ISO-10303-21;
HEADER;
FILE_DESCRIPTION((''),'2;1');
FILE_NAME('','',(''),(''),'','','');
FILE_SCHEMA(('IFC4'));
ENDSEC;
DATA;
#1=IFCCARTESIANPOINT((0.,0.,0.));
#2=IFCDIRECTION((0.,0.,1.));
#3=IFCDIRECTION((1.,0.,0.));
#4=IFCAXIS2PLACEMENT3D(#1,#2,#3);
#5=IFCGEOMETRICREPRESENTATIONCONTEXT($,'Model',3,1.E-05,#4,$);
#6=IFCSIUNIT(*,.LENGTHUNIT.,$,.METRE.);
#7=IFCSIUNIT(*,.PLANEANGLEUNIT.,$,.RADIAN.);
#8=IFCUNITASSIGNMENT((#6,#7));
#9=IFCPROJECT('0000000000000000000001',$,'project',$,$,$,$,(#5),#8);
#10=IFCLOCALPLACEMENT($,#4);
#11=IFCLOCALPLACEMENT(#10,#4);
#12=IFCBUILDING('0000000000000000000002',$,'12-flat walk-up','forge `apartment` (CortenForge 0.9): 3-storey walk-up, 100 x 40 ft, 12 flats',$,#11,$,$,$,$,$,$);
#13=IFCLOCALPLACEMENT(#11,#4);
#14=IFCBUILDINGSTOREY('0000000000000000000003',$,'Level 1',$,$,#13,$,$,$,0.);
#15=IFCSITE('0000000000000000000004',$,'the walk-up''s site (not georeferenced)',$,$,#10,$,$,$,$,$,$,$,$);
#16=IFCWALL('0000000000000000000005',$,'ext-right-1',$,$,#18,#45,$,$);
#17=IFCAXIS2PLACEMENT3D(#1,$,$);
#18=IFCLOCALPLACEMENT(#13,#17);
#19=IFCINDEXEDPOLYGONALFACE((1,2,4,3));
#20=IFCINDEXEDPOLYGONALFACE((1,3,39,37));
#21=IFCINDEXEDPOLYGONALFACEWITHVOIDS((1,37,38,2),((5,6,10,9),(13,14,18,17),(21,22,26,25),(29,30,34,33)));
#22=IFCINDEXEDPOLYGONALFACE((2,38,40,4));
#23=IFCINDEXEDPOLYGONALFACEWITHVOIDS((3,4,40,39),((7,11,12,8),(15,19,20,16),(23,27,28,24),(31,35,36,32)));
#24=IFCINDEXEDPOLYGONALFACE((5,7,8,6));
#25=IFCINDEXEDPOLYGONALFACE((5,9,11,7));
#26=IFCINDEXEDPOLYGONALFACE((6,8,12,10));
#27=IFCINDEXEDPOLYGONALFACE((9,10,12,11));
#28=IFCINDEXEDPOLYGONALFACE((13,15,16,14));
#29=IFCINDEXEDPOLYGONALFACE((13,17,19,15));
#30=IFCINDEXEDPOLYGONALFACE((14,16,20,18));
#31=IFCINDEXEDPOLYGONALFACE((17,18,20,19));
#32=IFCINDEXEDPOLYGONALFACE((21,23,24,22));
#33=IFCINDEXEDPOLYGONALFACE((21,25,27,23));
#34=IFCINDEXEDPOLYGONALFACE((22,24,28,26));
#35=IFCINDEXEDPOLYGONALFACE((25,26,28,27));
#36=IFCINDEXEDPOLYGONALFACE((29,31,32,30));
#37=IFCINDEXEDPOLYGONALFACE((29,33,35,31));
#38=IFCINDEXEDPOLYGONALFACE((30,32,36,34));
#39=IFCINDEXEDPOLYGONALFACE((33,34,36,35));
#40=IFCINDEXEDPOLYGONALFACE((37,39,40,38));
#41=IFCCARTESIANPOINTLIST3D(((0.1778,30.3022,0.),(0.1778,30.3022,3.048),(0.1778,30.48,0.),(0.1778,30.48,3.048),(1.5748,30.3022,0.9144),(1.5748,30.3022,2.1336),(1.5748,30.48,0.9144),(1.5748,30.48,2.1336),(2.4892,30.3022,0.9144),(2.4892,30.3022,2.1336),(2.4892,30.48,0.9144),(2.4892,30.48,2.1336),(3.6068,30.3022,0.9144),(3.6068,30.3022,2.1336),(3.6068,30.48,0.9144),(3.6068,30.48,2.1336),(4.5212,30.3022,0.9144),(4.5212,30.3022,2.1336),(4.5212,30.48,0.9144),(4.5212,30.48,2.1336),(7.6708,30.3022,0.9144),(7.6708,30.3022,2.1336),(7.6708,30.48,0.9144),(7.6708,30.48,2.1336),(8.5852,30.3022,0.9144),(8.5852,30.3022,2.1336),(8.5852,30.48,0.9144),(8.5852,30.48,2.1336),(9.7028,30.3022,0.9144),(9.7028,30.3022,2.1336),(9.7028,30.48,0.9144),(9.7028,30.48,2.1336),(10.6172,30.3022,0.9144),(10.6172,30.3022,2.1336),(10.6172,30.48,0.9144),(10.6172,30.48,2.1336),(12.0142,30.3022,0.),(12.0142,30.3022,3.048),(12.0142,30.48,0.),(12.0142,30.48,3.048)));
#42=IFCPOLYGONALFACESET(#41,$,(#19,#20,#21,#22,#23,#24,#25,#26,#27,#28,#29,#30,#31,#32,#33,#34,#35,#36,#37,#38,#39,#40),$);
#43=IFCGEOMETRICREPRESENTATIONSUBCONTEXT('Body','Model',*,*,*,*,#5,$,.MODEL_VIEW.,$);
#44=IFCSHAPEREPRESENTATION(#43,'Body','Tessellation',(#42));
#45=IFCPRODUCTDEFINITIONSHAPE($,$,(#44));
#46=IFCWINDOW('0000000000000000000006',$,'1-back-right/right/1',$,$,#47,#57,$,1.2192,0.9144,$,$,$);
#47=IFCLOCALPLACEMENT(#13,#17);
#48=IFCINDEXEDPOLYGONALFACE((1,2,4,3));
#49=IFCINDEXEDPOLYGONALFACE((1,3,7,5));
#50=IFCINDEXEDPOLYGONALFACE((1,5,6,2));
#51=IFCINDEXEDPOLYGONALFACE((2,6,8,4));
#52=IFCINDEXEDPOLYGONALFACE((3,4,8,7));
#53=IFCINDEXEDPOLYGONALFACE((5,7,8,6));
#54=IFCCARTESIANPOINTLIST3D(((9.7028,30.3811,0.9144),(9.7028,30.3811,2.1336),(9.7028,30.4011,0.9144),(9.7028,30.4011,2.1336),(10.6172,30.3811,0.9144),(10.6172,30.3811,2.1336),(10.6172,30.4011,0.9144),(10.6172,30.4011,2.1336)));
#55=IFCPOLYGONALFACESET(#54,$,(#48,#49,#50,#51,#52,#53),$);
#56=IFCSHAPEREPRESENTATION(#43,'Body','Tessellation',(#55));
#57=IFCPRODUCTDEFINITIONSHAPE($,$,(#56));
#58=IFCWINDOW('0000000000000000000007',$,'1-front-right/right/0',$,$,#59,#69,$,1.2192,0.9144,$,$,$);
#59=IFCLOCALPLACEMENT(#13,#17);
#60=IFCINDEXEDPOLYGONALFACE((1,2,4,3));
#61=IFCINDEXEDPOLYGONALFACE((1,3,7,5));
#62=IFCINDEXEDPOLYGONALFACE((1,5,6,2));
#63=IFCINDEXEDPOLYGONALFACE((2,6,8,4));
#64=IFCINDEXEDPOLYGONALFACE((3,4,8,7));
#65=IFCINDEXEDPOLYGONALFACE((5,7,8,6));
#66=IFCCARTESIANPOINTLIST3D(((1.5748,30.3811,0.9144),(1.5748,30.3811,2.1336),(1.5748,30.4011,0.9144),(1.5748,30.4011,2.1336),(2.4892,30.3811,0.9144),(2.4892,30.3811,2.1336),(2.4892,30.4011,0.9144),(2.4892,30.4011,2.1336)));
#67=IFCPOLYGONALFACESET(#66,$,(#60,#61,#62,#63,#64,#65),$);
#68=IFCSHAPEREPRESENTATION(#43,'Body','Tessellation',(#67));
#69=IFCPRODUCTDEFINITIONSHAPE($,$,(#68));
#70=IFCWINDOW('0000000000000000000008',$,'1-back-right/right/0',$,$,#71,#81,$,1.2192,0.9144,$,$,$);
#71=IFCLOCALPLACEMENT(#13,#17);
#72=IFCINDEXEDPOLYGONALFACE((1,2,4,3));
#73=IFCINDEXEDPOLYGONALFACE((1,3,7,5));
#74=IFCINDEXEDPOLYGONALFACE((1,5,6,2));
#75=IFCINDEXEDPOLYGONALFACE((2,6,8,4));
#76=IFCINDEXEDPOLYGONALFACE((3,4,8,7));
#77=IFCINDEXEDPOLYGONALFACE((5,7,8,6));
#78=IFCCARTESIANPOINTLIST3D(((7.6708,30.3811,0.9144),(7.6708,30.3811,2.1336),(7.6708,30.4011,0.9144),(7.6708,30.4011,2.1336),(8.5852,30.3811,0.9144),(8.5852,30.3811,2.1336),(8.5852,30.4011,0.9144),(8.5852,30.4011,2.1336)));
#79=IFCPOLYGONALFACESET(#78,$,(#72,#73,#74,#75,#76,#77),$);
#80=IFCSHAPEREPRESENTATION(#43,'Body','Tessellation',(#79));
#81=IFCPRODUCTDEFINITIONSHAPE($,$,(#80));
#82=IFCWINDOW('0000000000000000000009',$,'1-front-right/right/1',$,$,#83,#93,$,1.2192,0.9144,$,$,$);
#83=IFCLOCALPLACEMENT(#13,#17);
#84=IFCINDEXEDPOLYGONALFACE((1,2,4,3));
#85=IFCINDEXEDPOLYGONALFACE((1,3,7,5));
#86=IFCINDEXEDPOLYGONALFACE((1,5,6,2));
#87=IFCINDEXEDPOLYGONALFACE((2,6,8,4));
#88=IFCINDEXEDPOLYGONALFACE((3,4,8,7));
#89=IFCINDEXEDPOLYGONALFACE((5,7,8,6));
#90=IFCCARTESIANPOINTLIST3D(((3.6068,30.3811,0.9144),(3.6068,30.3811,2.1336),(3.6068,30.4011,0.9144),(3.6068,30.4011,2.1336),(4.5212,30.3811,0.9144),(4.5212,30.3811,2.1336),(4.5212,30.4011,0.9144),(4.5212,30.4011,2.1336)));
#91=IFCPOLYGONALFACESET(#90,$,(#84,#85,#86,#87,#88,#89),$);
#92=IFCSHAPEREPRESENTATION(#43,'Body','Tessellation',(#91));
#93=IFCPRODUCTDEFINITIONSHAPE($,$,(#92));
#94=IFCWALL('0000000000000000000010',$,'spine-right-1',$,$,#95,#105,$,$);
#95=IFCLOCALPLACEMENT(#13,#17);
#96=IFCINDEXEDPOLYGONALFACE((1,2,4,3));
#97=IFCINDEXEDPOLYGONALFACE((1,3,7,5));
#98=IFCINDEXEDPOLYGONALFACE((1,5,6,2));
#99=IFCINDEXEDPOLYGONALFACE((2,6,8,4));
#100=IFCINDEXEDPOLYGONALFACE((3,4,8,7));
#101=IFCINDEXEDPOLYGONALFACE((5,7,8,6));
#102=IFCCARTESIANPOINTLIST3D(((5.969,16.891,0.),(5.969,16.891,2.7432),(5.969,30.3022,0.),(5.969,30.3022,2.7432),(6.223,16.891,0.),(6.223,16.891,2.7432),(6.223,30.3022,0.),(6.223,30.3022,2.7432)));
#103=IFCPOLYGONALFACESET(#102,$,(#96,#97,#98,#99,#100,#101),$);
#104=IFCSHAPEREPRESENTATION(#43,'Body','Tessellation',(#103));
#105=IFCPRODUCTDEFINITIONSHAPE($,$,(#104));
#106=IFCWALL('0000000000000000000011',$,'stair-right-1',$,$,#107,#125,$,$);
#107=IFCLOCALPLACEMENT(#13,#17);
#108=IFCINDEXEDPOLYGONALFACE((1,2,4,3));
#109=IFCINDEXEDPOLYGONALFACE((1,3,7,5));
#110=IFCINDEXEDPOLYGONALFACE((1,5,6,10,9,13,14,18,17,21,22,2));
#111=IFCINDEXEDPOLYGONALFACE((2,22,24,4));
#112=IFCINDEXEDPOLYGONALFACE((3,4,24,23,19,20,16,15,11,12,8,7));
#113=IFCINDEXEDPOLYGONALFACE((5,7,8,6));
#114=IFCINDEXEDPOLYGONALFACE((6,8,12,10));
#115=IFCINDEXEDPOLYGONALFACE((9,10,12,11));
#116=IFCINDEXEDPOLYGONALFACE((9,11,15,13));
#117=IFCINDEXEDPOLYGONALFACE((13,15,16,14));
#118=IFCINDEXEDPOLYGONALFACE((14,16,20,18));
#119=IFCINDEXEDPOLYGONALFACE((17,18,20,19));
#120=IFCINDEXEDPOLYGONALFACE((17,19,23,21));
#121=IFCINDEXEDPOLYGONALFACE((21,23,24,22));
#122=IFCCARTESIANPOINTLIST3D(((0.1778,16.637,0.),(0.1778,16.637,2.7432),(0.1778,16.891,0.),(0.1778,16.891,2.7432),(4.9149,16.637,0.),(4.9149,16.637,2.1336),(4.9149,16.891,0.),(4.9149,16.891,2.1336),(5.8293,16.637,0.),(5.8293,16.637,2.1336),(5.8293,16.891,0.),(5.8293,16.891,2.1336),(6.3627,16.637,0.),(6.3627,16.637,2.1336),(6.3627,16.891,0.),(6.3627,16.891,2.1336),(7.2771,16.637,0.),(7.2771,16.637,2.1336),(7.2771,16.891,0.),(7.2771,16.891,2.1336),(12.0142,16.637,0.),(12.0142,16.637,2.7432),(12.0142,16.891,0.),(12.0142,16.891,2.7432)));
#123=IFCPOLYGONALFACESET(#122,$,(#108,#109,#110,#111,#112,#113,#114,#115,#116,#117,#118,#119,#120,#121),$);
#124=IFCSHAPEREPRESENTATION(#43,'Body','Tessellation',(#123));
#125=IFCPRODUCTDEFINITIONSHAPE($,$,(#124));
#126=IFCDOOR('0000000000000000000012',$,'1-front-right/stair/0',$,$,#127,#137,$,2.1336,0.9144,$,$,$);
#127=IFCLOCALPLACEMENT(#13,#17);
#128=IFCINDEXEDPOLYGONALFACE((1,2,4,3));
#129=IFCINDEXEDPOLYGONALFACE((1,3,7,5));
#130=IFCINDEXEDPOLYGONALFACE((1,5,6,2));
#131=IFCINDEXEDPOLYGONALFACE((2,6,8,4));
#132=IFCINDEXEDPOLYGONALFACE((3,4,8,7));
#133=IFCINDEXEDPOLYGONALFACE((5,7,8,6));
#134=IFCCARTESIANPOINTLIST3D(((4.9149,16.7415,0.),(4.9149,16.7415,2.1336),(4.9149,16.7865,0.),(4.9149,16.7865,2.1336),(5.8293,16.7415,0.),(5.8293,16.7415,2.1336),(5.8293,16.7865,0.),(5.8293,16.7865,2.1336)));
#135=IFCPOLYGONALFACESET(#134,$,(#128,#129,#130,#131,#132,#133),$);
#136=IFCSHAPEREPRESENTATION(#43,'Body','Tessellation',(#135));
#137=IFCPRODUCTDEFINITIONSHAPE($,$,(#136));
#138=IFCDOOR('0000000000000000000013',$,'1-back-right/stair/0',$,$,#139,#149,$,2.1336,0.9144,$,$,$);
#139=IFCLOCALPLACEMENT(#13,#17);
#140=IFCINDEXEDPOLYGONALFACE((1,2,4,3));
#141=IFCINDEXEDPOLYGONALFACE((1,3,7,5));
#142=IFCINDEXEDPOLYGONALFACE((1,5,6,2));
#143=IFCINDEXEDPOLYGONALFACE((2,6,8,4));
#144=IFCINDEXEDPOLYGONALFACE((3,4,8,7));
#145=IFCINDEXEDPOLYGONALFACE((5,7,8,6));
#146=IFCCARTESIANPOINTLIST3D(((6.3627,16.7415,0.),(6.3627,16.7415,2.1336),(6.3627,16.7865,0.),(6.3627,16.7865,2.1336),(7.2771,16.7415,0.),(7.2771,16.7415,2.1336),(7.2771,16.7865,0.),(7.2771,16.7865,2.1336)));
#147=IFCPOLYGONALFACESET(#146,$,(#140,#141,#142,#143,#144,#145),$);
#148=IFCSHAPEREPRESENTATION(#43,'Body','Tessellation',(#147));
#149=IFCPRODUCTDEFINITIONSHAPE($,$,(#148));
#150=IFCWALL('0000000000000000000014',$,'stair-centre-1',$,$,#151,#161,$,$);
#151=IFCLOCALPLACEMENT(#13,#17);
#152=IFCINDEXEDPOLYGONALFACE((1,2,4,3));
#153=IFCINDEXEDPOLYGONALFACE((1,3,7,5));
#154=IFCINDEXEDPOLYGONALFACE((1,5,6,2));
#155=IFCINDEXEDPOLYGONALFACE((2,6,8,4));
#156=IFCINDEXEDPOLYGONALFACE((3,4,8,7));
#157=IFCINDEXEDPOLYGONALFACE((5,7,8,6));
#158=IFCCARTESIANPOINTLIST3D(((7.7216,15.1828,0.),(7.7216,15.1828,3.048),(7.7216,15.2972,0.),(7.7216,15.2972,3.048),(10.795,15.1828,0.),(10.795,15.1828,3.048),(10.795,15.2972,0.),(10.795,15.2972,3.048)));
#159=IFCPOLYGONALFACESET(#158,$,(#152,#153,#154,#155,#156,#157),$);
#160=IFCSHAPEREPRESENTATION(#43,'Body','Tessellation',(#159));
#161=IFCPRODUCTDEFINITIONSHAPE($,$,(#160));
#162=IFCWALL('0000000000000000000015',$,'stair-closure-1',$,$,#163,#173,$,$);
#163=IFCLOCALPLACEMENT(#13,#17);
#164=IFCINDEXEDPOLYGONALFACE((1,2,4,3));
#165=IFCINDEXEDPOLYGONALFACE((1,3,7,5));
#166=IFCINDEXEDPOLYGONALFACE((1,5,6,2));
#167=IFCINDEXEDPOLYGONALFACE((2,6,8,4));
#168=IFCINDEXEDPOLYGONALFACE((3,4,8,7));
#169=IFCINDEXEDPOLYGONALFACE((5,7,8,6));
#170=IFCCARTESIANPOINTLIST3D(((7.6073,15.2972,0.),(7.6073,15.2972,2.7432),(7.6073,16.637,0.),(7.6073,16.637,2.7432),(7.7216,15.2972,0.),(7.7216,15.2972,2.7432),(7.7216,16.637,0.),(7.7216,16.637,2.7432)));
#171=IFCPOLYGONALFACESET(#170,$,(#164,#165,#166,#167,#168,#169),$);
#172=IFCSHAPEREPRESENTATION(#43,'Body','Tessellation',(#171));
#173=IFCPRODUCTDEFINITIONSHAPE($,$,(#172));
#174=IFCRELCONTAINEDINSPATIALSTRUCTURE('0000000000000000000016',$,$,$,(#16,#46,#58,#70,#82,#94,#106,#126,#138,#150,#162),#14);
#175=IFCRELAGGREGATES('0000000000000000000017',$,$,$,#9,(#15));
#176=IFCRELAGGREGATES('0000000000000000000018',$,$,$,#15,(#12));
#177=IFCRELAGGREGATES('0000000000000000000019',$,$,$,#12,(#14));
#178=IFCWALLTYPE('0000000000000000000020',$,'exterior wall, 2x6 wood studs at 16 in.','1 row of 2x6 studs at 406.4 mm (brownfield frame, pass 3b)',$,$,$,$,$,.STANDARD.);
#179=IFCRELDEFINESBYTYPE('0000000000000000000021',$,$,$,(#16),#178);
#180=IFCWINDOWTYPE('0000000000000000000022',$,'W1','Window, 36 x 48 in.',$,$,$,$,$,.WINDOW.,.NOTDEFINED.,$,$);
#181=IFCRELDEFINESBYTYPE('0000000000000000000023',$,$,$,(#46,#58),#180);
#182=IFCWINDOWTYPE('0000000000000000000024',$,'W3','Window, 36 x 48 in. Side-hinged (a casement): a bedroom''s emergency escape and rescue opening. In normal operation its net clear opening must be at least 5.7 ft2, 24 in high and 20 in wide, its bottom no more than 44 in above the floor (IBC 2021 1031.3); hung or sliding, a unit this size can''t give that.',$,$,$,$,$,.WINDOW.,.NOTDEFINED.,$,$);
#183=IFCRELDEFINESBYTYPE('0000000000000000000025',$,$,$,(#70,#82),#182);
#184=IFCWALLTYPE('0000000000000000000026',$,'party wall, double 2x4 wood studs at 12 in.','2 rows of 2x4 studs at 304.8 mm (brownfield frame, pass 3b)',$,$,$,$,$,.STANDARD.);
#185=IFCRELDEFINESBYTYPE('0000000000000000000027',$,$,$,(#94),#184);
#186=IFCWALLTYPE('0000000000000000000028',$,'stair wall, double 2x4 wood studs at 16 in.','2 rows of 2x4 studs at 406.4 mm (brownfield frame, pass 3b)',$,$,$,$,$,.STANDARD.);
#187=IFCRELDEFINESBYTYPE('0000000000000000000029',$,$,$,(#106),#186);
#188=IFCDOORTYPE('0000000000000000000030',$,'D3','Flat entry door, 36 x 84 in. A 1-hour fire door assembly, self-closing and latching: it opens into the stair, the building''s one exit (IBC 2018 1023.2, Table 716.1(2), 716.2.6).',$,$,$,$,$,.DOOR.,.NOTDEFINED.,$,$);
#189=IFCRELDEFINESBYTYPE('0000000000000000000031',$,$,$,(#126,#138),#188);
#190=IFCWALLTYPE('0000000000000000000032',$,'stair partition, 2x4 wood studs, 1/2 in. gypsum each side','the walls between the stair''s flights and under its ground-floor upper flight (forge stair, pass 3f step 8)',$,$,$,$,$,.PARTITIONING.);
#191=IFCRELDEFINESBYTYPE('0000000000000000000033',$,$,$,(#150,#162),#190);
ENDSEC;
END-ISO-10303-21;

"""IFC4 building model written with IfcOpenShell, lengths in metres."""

from ifc_helpers import new_model, si_unit, frame, frame_2d, origin, origin_with_axes, place, context, subcontext, project, spatial, rectangle, extrude, type_object, element, fill, save


model = new_model("IFC4")

# Units and contexts
model_context = context("Model", 3, precision=1e-05, world=origin_with_axes())
body_context = subcontext(model_context, "Body", "Model", "MODEL_VIEW")
ifc_project = project(units=[si_unit("LENGTHUNIT", "METRE"), si_unit("PLANEANGLEUNIT", "RADIAN")], contexts=[model_context])

# Site, building, storey
site_placement = place(None, origin_with_axes())
site = spatial("IfcSite", under=ifc_project, at=site_placement, Name="the walk-up's site (not georeferenced)")
building_placement = place(site_placement, origin_with_axes())
building = spatial("IfcBuilding", under=site, at=building_placement, Name="12-flat walk-up", Description="forge `apartment` (CortenForge 0.9): 3-storey walk-up, 100 x 40 ft, 12 flats")
storey_placement = place(building_placement, origin_with_axes())
storey = spatial("IfcBuildingStorey", under=building, at=storey_placement, Name="Level 1", Elevation=0.0)

# Wall, openings, windows
wall_type_1 = type_object("IfcWallType", Name="exterior wall, 2x6 wood studs at 16 in.", Description="1 row of 2x6 studs at 406.4 mm (brownfield frame, pass 3b)", PredefinedType="STANDARD")
wall_1_placement = place(storey_placement, frame((0.1778, 30.3022, 0.0), z_axis=(0.0, 0.0, 1.0), x_axis=(1.0, 0.0, 0.0)))
wall_1 = element("IfcWall", 1, at=wall_1_placement, inside=storey, type_object=wall_type_1, Name="ext-right-1", context=body_context, shape_type="SweptSolid", body=[
    extrude(rectangle(XDim=11.8364, YDim=0.1778, at=frame_2d((5.9182, 0.0889))), origin(), (0.0, 0.0, 1.0), 3.048),
])
opening_1_placement = place(wall_1_placement, frame((8.4074, 0.1778, 0.9144), z_axis=(0.0, 0.0, 1.0), x_axis=(-1.0, 0.0, 0.0)))
opening_1 = element("IfcOpeningElement", 2, at=opening_1_placement, cuts=wall_1, PredefinedType="OPENING", context=body_context, shape_type="SweptSolid", body=[
    extrude(rectangle(XDim=0.9144, YDim=0.1778, at=frame_2d((0.4572, 0.0889))), origin(), (0.0, 0.0, 1.0), 1.2192),
])
opening_2_placement = place(wall_1_placement, frame((10.4394, 0.1778, 0.9144), z_axis=(0.0, 0.0, 1.0), x_axis=(-1.0, 0.0, 0.0)))
opening_2 = element("IfcOpeningElement", 3, at=opening_2_placement, cuts=wall_1, PredefinedType="OPENING", context=body_context, shape_type="SweptSolid", body=[
    extrude(rectangle(XDim=0.9144, YDim=0.1778, at=frame_2d((0.4572, 0.0889))), origin(), (0.0, 0.0, 1.0), 1.2192),
])
opening_3_placement = place(wall_1_placement, frame((2.3114, 0.1778, 0.9144), z_axis=(0.0, 0.0, 1.0), x_axis=(-1.0, 0.0, 0.0)))
opening_3 = element("IfcOpeningElement", 4, at=opening_3_placement, cuts=wall_1, PredefinedType="OPENING", context=body_context, shape_type="SweptSolid", body=[
    extrude(rectangle(XDim=0.9144, YDim=0.1778, at=frame_2d((0.4572, 0.0889))), origin(), (0.0, 0.0, 1.0), 1.2192),
])
opening_4_placement = place(wall_1_placement, frame((4.3434, 0.1778, 0.9144), z_axis=(0.0, 0.0, 1.0), x_axis=(-1.0, 0.0, 0.0)))
opening_4 = element("IfcOpeningElement", 5, at=opening_4_placement, cuts=wall_1, PredefinedType="OPENING", context=body_context, shape_type="SweptSolid", body=[
    extrude(rectangle(XDim=0.9144, YDim=0.1778, at=frame_2d((0.4572, 0.0889))), origin(), (0.0, 0.0, 1.0), 1.2192),
])
window_type_1 = type_object("IfcWindowType", Name="W1", Description="Window, 36 x 48 in.", PartitioningType="NOTDEFINED", PredefinedType="WINDOW")
window_1_placement = place(opening_2_placement, frame((0.0, 0.0789, 0.0), z_axis=(0.0, 0.0, 1.0), x_axis=(1.0, 0.0, 0.0)))
window_1 = element("IfcWindow", 6, at=window_1_placement, inside=storey, type_object=window_type_1, Name="1-back-right/right/1", OverallHeight=1.2192, OverallWidth=0.9144, context=body_context, shape_type="SweptSolid", body=[
    extrude(rectangle(XDim=0.9144, YDim=0.02, at=frame_2d((0.4572, 0.01))), origin(), (0.0, 0.0, 1.0), 1.2192),
])
fill(opening_2, window_1)
window_2_placement = place(opening_3_placement, frame((0.0, 0.0789, 0.0), z_axis=(0.0, 0.0, 1.0), x_axis=(1.0, 0.0, 0.0)))
window_2 = element("IfcWindow", 7, at=window_2_placement, inside=storey, type_object=window_type_1, Name="1-front-right/right/0", OverallHeight=1.2192, OverallWidth=0.9144, context=body_context, shape_type="SweptSolid", body=[
    extrude(rectangle(XDim=0.9144, YDim=0.02, at=frame_2d((0.4572, 0.01))), origin(), (0.0, 0.0, 1.0), 1.2192),
])
fill(opening_3, window_2)
window_type_2 = type_object("IfcWindowType", Name="W3", Description="Window, 36 x 48 in. Side-hinged (a casement): a bedroom's emergency escape and rescue opening. In normal operation its net clear opening must be at least 5.7 ft2, 24 in high and 20 in wide, its bottom no more than 44 in above the floor (IBC 2021 1031.3); hung or sliding, a unit this size can't give that.", PartitioningType="NOTDEFINED", PredefinedType="WINDOW")
window_3_placement = place(opening_1_placement, frame((0.0, 0.0789, 0.0), z_axis=(0.0, 0.0, 1.0), x_axis=(1.0, 0.0, 0.0)))
window_3 = element("IfcWindow", 8, at=window_3_placement, inside=storey, type_object=window_type_2, Name="1-back-right/right/0", OverallHeight=1.2192, OverallWidth=0.9144, context=body_context, shape_type="SweptSolid", body=[
    extrude(rectangle(XDim=0.9144, YDim=0.02, at=frame_2d((0.4572, 0.01))), origin(), (0.0, 0.0, 1.0), 1.2192),
])
fill(opening_1, window_3)
window_4_placement = place(opening_4_placement, frame((0.0, 0.0789, 0.0), z_axis=(0.0, 0.0, 1.0), x_axis=(1.0, 0.0, 0.0)))
window_4 = element("IfcWindow", 9, at=window_4_placement, inside=storey, type_object=window_type_2, Name="1-front-right/right/1", OverallHeight=1.2192, OverallWidth=0.9144, context=body_context, shape_type="SweptSolid", body=[
    extrude(rectangle(XDim=0.9144, YDim=0.02, at=frame_2d((0.4572, 0.01))), origin(), (0.0, 0.0, 1.0), 1.2192),
])
fill(opening_4, window_4)

# Wall
wall_type_2 = type_object("IfcWallType", Name="party wall, double 2x4 wood studs at 12 in.", Description="2 rows of 2x4 studs at 304.8 mm (brownfield frame, pass 3b)", PredefinedType="STANDARD")
wall_2_placement = place(storey_placement, frame((5.969, 16.891, 0.0), z_axis=(0.0, 0.0, 1.0), x_axis=(1.0, 0.0, 0.0)))
element("IfcWall", 10, at=wall_2_placement, inside=storey, type_object=wall_type_2, Name="spine-right-1", context=body_context, shape_type="SweptSolid", body=[
    extrude(rectangle(XDim=0.254, YDim=13.4112, at=frame_2d((0.127, 6.7056))), origin(), (0.0, 0.0, 1.0), 2.7432),
])

# Wall, openings, doors
wall_type_3 = type_object("IfcWallType", Name="stair wall, double 2x4 wood studs at 16 in.", Description="2 rows of 2x4 studs at 406.4 mm (brownfield frame, pass 3b)", PredefinedType="STANDARD")
wall_3_placement = place(storey_placement, frame((0.1778, 16.637, 0.0), z_axis=(0.0, 0.0, 1.0), x_axis=(1.0, 0.0, 0.0)))
wall_3 = element("IfcWall", 11, at=wall_3_placement, inside=storey, type_object=wall_type_3, Name="stair-right-1", context=body_context, shape_type="SweptSolid", body=[
    extrude(rectangle(XDim=11.8364, YDim=0.254, at=frame_2d((5.9182, 0.127))), origin(), (0.0, 0.0, 1.0), 2.7432),
])
opening_5_placement = place(wall_3_placement, frame((5.6515, 0.254, 0.0), z_axis=(0.0, 0.0, 1.0), x_axis=(-1.0, 0.0, 0.0)))
opening_5 = element("IfcOpeningElement", 12, at=opening_5_placement, cuts=wall_3, PredefinedType="OPENING", context=body_context, shape_type="SweptSolid", body=[
    extrude(rectangle(XDim=0.9144, YDim=0.254, at=frame_2d((0.4572, 0.127))), origin(), (0.0, 0.0, 1.0), 2.1336),
])
opening_6_placement = place(wall_3_placement, frame((7.0993, 0.254, 0.0), z_axis=(0.0, 0.0, 1.0), x_axis=(-1.0, 0.0, 0.0)))
opening_6 = element("IfcOpeningElement", 13, at=opening_6_placement, cuts=wall_3, PredefinedType="OPENING", context=body_context, shape_type="SweptSolid", body=[
    extrude(rectangle(XDim=0.9144, YDim=0.254, at=frame_2d((0.4572, 0.127))), origin(), (0.0, 0.0, 1.0), 2.1336),
])
door_type = type_object("IfcDoorType", Name="D3", Description="Flat entry door, 36 x 84 in. A 1-hour fire door assembly, self-closing and latching: it opens into the stair, the building's one exit (IBC 2018 1023.2, Table 716.1(2), 716.2.6).", OperationType="NOTDEFINED", PredefinedType="DOOR")
door_1_placement = place(opening_5_placement, frame((0.0, 0.1045, 0.0), z_axis=(0.0, 0.0, 1.0), x_axis=(1.0, 0.0, 0.0)))
door_1 = element("IfcDoor", 14, at=door_1_placement, inside=storey, type_object=door_type, Name="1-front-right/stair/0", OverallHeight=2.1336, OverallWidth=0.9144, context=body_context, shape_type="SweptSolid", body=[
    extrude(rectangle(XDim=0.9144, YDim=0.045, at=frame_2d((0.4572, 0.0225))), origin(), (0.0, 0.0, 1.0), 2.1336),
])
fill(opening_5, door_1)
door_2_placement = place(opening_6_placement, frame((0.0, 0.1045, 0.0), z_axis=(0.0, 0.0, 1.0), x_axis=(1.0, 0.0, 0.0)))
door_2 = element("IfcDoor", 15, at=door_2_placement, inside=storey, type_object=door_type, Name="1-back-right/stair/0", OverallHeight=2.1336, OverallWidth=0.9144, context=body_context, shape_type="SweptSolid", body=[
    extrude(rectangle(XDim=0.9144, YDim=0.045, at=frame_2d((0.4572, 0.0225))), origin(), (0.0, 0.0, 1.0), 2.1336),
])
fill(opening_6, door_2)

# Walls
wall_type_4 = type_object("IfcWallType", Name="stair partition, 2x4 wood studs, 1/2 in. gypsum each side", Description="the walls between the stair's flights and under its ground-floor upper flight (forge stair, pass 3f step 8)", PredefinedType="PARTITIONING")
wall_4_placement = place(storey_placement, frame((7.7216, 15.1829, 0.0), z_axis=(0.0, 0.0, 1.0), x_axis=(1.0, 0.0, 0.0)))
element("IfcWall", 16, at=wall_4_placement, inside=storey, type_object=wall_type_4, Name="stair-centre-1", context=body_context, shape_type="SweptSolid", body=[
    extrude(rectangle(XDim=3.0734, YDim=0.1143, at=frame_2d((1.5367, 0.0572))), origin(), (0.0, 0.0, 1.0), 3.048),
])
wall_5_placement = place(storey_placement, frame((7.6073, 15.2972, 0.0), z_axis=(0.0, 0.0, 1.0), x_axis=(1.0, 0.0, 0.0)))
element("IfcWall", 17, at=wall_5_placement, inside=storey, type_object=wall_type_4, Name="stair-closure-1", context=body_context, shape_type="SweptSolid", body=[
    extrude(rectangle(XDim=0.1143, YDim=1.3399, at=frame_2d((0.0571, 0.6699))), origin(), (0.0, 0.0, 1.0), 2.7432),
])

save(model, "model.ifc")
